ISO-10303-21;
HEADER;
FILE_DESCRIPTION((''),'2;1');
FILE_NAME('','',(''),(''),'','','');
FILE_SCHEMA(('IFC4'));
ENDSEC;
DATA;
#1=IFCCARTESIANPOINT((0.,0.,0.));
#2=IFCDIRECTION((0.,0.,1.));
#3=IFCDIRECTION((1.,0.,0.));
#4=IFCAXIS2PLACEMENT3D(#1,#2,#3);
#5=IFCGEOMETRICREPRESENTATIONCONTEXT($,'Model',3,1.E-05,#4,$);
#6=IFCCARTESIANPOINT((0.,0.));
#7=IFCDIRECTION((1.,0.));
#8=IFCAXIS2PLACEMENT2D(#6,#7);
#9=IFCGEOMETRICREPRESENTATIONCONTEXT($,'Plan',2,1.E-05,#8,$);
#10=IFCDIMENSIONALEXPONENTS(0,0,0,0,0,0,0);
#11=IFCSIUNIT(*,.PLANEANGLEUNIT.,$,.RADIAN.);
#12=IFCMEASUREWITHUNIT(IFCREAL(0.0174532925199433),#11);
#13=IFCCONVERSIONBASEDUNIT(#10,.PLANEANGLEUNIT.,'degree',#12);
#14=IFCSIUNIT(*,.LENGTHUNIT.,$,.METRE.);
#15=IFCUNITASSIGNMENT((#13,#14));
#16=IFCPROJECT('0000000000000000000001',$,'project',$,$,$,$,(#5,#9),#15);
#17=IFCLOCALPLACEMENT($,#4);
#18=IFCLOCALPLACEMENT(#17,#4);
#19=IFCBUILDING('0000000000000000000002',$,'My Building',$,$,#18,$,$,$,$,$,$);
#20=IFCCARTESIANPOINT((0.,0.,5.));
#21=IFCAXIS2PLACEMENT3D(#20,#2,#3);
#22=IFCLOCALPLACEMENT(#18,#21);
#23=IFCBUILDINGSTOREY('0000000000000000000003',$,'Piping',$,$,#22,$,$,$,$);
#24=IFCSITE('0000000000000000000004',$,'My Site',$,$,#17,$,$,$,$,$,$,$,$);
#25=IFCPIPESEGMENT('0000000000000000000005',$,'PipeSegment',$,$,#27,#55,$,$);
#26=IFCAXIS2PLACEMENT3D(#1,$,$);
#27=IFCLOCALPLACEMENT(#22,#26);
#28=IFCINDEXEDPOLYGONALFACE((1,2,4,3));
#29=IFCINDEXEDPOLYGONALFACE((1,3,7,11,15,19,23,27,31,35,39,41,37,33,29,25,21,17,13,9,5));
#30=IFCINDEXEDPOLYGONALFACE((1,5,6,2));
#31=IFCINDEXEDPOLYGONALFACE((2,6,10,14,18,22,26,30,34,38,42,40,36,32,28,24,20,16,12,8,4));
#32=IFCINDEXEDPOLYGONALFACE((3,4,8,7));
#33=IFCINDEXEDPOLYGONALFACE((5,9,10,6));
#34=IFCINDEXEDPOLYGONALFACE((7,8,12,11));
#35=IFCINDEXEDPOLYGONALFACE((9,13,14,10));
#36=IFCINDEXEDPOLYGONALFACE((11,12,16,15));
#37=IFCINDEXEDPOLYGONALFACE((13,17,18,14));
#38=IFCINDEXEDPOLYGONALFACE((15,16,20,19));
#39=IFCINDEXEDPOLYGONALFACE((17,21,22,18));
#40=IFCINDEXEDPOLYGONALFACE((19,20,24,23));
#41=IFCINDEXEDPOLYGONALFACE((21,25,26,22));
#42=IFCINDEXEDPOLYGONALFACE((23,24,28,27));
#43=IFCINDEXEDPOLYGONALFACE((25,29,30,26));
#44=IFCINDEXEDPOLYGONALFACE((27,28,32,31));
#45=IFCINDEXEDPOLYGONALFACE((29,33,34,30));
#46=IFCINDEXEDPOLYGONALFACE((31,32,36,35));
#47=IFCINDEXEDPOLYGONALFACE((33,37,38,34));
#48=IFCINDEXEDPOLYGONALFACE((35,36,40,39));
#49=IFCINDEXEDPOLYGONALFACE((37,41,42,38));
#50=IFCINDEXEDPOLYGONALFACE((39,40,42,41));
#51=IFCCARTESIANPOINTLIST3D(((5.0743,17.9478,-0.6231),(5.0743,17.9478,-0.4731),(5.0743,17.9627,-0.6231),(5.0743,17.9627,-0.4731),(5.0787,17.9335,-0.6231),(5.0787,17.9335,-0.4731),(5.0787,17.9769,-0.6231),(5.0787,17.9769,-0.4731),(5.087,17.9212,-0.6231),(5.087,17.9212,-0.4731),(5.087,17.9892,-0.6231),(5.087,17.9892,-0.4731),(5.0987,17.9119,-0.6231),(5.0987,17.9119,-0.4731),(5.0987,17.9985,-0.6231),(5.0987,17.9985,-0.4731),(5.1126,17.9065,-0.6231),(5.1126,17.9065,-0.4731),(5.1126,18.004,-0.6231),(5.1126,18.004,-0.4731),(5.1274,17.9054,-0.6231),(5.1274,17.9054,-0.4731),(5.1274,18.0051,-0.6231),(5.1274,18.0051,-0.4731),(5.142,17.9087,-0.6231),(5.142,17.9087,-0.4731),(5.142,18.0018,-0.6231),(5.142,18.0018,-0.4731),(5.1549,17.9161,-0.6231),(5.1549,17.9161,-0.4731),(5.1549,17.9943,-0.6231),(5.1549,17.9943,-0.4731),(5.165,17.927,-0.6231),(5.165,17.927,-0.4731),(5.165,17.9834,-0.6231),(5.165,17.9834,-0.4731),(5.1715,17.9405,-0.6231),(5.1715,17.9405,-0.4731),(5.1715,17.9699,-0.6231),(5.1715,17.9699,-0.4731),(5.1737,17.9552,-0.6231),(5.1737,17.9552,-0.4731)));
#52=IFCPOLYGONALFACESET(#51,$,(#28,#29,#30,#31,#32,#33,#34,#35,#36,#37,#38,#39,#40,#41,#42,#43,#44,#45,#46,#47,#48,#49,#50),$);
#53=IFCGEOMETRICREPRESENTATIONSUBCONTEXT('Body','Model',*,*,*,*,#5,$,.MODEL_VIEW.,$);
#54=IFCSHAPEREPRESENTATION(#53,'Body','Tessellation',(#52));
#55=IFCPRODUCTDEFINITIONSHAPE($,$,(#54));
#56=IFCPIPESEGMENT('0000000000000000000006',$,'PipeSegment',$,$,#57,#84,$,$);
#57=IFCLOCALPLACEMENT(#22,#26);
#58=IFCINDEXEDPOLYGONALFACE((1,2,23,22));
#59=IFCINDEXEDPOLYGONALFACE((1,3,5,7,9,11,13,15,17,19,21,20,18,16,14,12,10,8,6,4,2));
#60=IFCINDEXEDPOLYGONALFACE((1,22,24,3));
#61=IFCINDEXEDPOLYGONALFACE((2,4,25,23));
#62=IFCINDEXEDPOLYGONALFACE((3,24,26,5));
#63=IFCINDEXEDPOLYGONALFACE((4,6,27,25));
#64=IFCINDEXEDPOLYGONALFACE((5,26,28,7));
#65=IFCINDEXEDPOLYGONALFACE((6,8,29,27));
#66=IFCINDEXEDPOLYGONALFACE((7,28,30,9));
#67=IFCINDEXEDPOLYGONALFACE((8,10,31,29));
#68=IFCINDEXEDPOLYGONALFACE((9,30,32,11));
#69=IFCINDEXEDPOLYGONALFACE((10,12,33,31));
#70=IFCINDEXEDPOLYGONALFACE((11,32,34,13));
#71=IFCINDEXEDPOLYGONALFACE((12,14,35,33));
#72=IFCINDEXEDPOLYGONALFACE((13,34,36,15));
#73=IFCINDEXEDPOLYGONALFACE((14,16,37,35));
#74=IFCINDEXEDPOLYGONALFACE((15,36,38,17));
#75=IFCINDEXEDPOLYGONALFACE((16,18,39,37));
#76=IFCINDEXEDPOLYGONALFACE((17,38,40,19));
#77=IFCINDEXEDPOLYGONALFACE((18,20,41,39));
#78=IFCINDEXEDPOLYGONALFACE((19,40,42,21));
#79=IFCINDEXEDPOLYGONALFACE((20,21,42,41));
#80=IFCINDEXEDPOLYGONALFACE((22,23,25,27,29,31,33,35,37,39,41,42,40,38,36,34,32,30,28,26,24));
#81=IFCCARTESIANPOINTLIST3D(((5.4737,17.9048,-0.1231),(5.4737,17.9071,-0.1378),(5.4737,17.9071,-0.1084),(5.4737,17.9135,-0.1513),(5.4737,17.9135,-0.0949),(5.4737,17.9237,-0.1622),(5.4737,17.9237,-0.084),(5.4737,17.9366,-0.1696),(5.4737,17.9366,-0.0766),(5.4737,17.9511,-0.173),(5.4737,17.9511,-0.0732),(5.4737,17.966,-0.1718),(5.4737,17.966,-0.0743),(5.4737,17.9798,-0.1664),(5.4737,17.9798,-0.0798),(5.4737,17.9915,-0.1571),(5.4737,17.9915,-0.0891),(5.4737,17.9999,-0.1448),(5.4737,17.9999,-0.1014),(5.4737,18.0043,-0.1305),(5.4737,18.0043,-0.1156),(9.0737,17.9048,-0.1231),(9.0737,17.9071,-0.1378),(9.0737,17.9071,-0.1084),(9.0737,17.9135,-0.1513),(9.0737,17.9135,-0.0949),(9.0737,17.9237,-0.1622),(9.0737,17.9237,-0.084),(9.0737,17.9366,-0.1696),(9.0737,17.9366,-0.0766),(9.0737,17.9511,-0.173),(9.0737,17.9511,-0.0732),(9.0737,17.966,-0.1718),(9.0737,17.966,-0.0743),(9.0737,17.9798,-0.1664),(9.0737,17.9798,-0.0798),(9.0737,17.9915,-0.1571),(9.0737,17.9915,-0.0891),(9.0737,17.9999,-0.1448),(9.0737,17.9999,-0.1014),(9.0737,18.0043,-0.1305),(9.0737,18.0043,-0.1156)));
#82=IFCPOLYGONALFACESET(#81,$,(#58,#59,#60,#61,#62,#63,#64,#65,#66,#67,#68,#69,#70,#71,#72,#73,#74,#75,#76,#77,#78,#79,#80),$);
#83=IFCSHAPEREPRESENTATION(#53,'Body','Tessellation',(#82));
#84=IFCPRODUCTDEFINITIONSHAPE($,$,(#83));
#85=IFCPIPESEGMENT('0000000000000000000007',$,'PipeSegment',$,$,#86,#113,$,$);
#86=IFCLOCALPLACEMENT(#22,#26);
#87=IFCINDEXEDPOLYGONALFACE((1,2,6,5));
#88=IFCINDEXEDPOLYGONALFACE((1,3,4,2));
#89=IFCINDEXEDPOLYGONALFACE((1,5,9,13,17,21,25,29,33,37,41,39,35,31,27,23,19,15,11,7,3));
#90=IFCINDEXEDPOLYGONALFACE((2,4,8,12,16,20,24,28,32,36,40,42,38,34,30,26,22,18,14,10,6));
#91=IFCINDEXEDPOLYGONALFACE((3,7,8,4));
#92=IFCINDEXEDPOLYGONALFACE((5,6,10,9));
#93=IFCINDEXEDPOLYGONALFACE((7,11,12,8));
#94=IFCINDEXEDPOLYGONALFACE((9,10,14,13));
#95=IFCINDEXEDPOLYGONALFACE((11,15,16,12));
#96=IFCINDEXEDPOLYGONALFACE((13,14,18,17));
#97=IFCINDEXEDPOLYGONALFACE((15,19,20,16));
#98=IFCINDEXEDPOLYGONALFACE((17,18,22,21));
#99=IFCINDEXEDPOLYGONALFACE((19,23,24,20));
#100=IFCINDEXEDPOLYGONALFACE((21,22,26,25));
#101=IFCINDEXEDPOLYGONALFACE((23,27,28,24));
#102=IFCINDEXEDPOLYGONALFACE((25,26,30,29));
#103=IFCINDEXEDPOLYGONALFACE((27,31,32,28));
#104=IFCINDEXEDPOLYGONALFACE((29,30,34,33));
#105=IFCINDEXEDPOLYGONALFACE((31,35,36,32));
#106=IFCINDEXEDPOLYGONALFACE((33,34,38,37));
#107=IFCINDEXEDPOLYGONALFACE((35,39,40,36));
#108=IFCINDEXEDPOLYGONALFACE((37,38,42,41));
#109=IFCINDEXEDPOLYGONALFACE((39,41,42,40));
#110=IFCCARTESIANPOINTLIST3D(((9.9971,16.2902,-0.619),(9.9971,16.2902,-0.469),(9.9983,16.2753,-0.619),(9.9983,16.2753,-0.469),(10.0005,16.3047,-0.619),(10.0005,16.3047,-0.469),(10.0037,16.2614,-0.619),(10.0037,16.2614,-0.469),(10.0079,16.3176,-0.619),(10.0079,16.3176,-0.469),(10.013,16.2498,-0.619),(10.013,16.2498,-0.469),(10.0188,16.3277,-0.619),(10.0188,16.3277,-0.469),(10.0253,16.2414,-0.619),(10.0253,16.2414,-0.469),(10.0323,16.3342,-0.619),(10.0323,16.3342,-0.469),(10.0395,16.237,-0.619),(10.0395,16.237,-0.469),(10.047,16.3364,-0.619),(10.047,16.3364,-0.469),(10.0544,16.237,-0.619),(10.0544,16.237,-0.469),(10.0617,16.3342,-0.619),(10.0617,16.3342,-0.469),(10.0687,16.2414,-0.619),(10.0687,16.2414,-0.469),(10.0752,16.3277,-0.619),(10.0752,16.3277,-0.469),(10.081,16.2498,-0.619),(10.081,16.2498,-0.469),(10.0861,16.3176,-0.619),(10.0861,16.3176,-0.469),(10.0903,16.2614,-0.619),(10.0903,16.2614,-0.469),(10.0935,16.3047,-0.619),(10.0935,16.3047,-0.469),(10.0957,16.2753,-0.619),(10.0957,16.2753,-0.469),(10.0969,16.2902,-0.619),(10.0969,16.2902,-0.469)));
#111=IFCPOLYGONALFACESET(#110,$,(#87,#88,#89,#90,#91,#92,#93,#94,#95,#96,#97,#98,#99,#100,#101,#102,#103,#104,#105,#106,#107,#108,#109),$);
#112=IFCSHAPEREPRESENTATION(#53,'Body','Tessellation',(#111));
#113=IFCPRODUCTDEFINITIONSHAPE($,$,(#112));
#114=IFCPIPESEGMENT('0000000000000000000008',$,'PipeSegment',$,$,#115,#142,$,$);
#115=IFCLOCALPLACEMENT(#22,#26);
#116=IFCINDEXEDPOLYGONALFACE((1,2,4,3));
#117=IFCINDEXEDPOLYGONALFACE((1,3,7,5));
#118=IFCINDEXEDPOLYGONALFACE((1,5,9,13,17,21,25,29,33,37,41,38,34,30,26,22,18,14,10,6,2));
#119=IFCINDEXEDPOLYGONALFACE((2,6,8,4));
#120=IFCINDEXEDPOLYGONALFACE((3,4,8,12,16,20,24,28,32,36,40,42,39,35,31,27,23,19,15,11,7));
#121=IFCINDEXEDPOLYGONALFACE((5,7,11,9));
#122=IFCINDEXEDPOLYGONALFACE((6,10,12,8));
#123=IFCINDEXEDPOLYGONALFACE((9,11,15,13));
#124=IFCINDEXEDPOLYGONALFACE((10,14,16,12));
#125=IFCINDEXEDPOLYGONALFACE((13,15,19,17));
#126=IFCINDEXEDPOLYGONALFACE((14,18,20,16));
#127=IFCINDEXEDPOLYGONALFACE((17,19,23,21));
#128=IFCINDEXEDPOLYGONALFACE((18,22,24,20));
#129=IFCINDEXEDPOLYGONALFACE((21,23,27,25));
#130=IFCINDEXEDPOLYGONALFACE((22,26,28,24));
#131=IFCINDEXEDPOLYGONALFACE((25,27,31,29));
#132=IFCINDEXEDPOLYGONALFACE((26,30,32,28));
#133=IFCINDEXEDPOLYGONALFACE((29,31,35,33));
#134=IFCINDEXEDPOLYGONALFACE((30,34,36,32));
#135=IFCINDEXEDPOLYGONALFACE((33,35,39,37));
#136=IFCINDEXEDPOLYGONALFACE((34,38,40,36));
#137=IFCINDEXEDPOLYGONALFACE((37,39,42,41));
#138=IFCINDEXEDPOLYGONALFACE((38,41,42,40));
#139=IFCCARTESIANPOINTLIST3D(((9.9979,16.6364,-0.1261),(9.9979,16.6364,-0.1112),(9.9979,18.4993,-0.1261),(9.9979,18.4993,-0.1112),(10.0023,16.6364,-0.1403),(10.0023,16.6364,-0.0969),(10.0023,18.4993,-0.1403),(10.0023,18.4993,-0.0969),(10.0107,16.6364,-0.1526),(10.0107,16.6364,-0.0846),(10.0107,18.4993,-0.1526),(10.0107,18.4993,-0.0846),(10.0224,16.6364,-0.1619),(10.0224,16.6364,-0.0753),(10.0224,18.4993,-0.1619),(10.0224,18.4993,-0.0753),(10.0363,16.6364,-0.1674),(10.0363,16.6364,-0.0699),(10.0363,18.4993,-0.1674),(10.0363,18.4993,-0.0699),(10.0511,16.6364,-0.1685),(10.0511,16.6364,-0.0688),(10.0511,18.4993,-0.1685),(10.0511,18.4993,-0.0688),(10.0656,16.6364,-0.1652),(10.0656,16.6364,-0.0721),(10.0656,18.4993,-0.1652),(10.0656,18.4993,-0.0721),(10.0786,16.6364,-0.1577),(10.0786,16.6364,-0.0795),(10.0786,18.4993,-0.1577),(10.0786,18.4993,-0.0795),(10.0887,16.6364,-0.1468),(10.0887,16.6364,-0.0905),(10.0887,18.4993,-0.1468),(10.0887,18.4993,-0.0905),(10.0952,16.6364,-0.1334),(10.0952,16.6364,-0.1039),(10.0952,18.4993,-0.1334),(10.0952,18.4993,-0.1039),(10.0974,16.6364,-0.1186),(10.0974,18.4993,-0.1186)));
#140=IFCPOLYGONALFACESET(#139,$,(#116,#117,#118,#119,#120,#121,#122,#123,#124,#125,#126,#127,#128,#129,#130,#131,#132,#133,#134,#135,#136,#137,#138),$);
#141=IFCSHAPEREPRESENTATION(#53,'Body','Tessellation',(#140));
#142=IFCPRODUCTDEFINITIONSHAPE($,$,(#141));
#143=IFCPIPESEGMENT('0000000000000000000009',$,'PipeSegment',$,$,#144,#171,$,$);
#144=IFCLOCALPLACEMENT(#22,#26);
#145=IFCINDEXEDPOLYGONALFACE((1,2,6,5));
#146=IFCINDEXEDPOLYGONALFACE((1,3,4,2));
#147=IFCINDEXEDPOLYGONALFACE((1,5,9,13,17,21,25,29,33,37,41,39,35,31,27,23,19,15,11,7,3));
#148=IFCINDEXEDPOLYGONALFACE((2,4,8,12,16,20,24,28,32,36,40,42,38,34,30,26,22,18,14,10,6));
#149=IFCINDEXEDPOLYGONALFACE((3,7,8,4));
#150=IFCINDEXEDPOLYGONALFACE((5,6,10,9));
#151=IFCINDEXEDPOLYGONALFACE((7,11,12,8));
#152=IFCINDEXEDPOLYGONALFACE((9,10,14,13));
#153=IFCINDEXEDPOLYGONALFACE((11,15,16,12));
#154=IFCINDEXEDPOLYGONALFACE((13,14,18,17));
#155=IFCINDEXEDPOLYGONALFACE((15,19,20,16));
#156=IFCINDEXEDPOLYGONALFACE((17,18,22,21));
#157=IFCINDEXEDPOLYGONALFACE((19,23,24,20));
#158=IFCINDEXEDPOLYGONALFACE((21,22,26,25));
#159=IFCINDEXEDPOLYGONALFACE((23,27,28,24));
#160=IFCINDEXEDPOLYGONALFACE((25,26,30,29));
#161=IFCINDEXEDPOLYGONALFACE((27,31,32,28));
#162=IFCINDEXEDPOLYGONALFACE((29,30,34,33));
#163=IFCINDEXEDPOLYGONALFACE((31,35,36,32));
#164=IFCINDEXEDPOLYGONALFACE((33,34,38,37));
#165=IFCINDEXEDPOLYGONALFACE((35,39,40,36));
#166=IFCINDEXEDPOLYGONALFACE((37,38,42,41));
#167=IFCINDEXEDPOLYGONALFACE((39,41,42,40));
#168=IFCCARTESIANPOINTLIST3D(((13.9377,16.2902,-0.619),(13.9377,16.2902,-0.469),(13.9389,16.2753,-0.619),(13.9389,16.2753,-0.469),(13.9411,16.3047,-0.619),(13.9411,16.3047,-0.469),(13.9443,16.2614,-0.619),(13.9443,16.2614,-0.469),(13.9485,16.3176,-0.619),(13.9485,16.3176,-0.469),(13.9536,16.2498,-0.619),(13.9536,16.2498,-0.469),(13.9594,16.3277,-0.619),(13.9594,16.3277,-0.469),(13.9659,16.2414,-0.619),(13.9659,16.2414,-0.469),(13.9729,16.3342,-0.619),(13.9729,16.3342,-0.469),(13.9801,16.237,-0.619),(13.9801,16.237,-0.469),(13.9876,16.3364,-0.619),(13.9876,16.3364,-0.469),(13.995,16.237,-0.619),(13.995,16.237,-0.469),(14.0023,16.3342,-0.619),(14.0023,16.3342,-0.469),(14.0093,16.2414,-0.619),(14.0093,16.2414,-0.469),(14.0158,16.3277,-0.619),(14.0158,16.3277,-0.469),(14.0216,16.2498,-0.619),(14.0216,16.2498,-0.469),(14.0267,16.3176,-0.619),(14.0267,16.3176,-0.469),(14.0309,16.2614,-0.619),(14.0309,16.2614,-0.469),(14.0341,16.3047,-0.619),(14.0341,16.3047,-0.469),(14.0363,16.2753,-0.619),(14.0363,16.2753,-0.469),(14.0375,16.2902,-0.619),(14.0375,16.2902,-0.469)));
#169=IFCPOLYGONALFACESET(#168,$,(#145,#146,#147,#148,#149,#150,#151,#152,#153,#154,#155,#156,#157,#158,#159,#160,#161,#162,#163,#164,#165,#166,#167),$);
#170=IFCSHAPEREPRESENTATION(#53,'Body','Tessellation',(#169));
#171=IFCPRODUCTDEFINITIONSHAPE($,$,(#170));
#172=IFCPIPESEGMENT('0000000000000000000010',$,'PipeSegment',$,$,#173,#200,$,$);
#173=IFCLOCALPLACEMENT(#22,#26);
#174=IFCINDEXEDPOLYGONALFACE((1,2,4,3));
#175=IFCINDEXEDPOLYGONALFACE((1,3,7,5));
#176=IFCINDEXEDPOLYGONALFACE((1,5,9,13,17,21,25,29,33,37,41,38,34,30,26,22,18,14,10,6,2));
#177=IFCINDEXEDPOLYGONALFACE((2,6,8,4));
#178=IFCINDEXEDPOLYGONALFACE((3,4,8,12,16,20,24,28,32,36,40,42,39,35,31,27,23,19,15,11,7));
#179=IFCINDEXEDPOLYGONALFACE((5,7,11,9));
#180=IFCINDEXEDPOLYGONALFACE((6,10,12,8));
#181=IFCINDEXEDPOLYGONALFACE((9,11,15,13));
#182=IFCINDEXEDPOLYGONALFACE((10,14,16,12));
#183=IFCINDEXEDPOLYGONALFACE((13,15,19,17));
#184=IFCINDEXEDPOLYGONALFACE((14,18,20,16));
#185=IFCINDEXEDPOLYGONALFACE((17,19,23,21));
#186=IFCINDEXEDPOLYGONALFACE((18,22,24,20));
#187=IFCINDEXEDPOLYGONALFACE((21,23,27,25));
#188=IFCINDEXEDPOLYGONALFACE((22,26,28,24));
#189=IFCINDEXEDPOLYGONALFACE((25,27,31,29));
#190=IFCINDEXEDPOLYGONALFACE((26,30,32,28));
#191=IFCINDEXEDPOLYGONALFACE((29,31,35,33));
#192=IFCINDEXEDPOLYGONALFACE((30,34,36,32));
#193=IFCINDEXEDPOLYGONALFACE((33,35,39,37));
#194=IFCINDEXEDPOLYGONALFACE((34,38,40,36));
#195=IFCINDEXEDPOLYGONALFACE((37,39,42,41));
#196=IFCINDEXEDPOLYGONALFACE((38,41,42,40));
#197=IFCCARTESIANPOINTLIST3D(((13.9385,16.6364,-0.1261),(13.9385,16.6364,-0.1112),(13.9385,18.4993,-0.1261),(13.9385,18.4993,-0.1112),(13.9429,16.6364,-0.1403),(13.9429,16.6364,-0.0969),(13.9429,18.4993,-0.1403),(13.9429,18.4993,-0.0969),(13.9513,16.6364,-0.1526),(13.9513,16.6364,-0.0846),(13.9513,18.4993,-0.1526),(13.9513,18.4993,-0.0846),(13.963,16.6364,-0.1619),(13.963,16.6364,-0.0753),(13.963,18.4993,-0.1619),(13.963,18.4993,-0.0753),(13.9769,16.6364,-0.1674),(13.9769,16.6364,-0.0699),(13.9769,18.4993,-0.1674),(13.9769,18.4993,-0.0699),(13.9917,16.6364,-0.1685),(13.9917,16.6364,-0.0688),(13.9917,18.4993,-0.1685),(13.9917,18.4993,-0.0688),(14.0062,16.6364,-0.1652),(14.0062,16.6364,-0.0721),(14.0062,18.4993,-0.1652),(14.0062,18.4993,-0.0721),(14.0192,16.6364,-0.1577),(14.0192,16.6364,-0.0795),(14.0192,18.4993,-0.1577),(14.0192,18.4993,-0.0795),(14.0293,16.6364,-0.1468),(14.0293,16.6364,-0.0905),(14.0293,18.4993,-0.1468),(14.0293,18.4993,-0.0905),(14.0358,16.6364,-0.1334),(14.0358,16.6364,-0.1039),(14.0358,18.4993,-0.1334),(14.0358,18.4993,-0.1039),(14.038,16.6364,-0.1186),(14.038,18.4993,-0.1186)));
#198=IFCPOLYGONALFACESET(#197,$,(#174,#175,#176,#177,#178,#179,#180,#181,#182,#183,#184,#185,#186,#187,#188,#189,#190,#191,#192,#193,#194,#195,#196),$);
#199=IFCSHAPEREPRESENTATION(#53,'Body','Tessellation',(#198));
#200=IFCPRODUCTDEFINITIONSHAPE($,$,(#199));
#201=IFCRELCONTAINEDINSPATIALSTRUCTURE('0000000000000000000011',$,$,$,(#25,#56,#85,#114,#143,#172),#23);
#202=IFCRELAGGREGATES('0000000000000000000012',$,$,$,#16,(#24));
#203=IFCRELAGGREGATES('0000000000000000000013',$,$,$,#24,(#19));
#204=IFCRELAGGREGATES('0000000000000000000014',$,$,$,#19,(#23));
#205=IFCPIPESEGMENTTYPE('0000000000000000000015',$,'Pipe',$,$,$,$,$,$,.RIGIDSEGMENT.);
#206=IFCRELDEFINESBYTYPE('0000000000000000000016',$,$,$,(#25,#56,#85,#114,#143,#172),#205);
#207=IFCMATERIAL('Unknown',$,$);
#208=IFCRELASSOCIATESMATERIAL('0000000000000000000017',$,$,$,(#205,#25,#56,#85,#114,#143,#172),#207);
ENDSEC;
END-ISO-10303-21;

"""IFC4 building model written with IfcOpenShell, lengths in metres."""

from ifc_helpers import new_model, entity, si_unit, converted_unit, frame, origin_with_axes, origin_2d_with_axis, place, context, subcontext, project, spatial, circle, extrude, material, material_profile, profile_set, profile_usage, type_object, element, save


model = new_model("IFC4")

# Units and contexts
model_context = context("Model", 3, precision=1e-05, world=origin_with_axes())
plan_context = context("Plan", 2, precision=1e-05, world=origin_2d_with_axis())
body_context = subcontext(model_context, "Body", "Model", "MODEL_VIEW")
ifc_project = project(units=[converted_unit("PLANEANGLEUNIT", "degree", entity("IfcReal", 0.0174532925199433), si_unit("PLANEANGLEUNIT", "RADIAN"), dimensions=[0, 0, 0, 0, 0, 0, 0]), si_unit("LENGTHUNIT", "METRE")], contexts=[model_context, plan_context])

# Site, building, storey
site_placement = place(None, origin_with_axes())
site = spatial("IfcSite", under=ifc_project, at=site_placement, Name="My Site")
building_placement = place(site_placement, origin_with_axes())
building = spatial("IfcBuilding", under=site, at=building_placement, Name="My Building")
storey_placement = place(building_placement, frame((0.0, 0.0, 5.0), z_axis=(0.0, 0.0, 1.0), x_axis=(1.0, 0.0, 0.0)))
storey = spatial("IfcBuildingStorey", under=building, at=storey_placement, Name="Piping")

# Pipe segments
ifc_material = material(Name="Unknown")
ifc_material_profile_1 = material_profile(ifc_material, circle(Radius=0.05))
ifc_profile_set_1 = profile_set([ifc_material_profile_1])
pipe_segment_type = type_object("IfcPipeSegmentType", Name="Pipe", PredefinedType="RIGIDSEGMENT", material=ifc_profile_set_1)
ifc_profile_usage_1 = profile_usage(ifc_profile_set_1, cardinal=5)
pipe_segment_1_placement = place(storey_placement, frame((5.1237, 17.9552, -0.4731), z_axis=(0.0, 0.0, -1.0), x_axis=(1.0, 0.0, 0.0)))
element("IfcPipeSegment", 1, at=pipe_segment_1_placement, inside=storey, type_object=pipe_segment_type, material=ifc_profile_usage_1, Name="PipeSegment", context=body_context, shape_type="SweptSolid", body=[
    extrude(circle(Radius=0.05), origin_with_axes(), (0.0, 0.0, 1.0), 0.15),
])
ifc_profile_usage_2 = profile_usage(ifc_profile_set_1, cardinal=5)
pipe_segment_2_placement = place(storey_placement, frame((9.0737, 17.9548, -0.1231), z_axis=(-1.0, 0.0, 0.0), x_axis=(0.0, -1.0, 0.0)))
element("IfcPipeSegment", 2, at=pipe_segment_2_placement, inside=storey, type_object=pipe_segment_type, material=ifc_profile_usage_2, Name="PipeSegment", context=body_context, shape_type="SweptSolid", body=[
    extrude(circle(Radius=0.05), origin_with_axes(), (0.0, 0.0, 1.0), 3.6),
])
ifc_profile_usage_3 = profile_usage(ifc_profile_set_1, cardinal=5)
pipe_segment_3_placement = place(storey_placement, frame((10.047, 16.2864, -0.469), z_axis=(0.0, 0.0, -1.0), x_axis=(0.000053, 1.0, 0.0)))
element("IfcPipeSegment", 3, at=pipe_segment_3_placement, inside=storey, type_object=pipe_segment_type, material=ifc_profile_usage_3, Name="PipeSegment", context=body_context, shape_type="SweptSolid", body=[
    extrude(circle(Radius=0.05), origin_with_axes(), (0.0, 0.0, 1.0), 0.15),
])
ifc_profile_usage_4 = profile_usage(ifc_profile_set_1, cardinal=5)
pipe_segment_4_placement = place(storey_placement, frame((10.0474, 18.4993, -0.1186), z_axis=(0.0, -1.0, 0.0), x_axis=(1.0, 0.0, 0.0)))
element("IfcPipeSegment", 4, at=pipe_segment_4_placement, inside=storey, type_object=pipe_segment_type, material=ifc_profile_usage_4, Name="PipeSegment", context=body_context, shape_type="SweptSolid", body=[
    extrude(circle(Radius=0.05), origin_with_axes(), (0.0, 0.0, 1.0), 1.8629),
])
ifc_profile_usage_5 = profile_usage(ifc_profile_set_1, cardinal=5)
pipe_segment_5_placement = place(storey_placement, frame((13.9876, 16.2864, -0.469), z_axis=(0.0, 0.0, -1.0), x_axis=(0.000053, 1.0, 0.0)))
element("IfcPipeSegment", 5, at=pipe_segment_5_placement, inside=storey, type_object=pipe_segment_type, material=ifc_profile_usage_5, Name="PipeSegment", context=body_context, shape_type="SweptSolid", body=[
    extrude(circle(Radius=0.05), origin_with_axes(), (0.0, 0.0, 1.0), 0.15),
])
ifc_profile_usage_6 = profile_usage(ifc_profile_set_1, cardinal=5)
pipe_segment_6_placement = place(storey_placement, frame((13.988, 18.4993, -0.1186), z_axis=(0.0, -1.0, 0.0), x_axis=(1.0, 0.0, 0.0)))
element("IfcPipeSegment", 6, at=pipe_segment_6_placement, inside=storey, type_object=pipe_segment_type, material=ifc_profile_usage_6, Name="PipeSegment", context=body_context, shape_type="SweptSolid", body=[
    extrude(circle(Radius=0.05), origin_with_axes(), (0.0, 0.0, 1.0), 1.8629),
])

save(model, "model.ifc")
